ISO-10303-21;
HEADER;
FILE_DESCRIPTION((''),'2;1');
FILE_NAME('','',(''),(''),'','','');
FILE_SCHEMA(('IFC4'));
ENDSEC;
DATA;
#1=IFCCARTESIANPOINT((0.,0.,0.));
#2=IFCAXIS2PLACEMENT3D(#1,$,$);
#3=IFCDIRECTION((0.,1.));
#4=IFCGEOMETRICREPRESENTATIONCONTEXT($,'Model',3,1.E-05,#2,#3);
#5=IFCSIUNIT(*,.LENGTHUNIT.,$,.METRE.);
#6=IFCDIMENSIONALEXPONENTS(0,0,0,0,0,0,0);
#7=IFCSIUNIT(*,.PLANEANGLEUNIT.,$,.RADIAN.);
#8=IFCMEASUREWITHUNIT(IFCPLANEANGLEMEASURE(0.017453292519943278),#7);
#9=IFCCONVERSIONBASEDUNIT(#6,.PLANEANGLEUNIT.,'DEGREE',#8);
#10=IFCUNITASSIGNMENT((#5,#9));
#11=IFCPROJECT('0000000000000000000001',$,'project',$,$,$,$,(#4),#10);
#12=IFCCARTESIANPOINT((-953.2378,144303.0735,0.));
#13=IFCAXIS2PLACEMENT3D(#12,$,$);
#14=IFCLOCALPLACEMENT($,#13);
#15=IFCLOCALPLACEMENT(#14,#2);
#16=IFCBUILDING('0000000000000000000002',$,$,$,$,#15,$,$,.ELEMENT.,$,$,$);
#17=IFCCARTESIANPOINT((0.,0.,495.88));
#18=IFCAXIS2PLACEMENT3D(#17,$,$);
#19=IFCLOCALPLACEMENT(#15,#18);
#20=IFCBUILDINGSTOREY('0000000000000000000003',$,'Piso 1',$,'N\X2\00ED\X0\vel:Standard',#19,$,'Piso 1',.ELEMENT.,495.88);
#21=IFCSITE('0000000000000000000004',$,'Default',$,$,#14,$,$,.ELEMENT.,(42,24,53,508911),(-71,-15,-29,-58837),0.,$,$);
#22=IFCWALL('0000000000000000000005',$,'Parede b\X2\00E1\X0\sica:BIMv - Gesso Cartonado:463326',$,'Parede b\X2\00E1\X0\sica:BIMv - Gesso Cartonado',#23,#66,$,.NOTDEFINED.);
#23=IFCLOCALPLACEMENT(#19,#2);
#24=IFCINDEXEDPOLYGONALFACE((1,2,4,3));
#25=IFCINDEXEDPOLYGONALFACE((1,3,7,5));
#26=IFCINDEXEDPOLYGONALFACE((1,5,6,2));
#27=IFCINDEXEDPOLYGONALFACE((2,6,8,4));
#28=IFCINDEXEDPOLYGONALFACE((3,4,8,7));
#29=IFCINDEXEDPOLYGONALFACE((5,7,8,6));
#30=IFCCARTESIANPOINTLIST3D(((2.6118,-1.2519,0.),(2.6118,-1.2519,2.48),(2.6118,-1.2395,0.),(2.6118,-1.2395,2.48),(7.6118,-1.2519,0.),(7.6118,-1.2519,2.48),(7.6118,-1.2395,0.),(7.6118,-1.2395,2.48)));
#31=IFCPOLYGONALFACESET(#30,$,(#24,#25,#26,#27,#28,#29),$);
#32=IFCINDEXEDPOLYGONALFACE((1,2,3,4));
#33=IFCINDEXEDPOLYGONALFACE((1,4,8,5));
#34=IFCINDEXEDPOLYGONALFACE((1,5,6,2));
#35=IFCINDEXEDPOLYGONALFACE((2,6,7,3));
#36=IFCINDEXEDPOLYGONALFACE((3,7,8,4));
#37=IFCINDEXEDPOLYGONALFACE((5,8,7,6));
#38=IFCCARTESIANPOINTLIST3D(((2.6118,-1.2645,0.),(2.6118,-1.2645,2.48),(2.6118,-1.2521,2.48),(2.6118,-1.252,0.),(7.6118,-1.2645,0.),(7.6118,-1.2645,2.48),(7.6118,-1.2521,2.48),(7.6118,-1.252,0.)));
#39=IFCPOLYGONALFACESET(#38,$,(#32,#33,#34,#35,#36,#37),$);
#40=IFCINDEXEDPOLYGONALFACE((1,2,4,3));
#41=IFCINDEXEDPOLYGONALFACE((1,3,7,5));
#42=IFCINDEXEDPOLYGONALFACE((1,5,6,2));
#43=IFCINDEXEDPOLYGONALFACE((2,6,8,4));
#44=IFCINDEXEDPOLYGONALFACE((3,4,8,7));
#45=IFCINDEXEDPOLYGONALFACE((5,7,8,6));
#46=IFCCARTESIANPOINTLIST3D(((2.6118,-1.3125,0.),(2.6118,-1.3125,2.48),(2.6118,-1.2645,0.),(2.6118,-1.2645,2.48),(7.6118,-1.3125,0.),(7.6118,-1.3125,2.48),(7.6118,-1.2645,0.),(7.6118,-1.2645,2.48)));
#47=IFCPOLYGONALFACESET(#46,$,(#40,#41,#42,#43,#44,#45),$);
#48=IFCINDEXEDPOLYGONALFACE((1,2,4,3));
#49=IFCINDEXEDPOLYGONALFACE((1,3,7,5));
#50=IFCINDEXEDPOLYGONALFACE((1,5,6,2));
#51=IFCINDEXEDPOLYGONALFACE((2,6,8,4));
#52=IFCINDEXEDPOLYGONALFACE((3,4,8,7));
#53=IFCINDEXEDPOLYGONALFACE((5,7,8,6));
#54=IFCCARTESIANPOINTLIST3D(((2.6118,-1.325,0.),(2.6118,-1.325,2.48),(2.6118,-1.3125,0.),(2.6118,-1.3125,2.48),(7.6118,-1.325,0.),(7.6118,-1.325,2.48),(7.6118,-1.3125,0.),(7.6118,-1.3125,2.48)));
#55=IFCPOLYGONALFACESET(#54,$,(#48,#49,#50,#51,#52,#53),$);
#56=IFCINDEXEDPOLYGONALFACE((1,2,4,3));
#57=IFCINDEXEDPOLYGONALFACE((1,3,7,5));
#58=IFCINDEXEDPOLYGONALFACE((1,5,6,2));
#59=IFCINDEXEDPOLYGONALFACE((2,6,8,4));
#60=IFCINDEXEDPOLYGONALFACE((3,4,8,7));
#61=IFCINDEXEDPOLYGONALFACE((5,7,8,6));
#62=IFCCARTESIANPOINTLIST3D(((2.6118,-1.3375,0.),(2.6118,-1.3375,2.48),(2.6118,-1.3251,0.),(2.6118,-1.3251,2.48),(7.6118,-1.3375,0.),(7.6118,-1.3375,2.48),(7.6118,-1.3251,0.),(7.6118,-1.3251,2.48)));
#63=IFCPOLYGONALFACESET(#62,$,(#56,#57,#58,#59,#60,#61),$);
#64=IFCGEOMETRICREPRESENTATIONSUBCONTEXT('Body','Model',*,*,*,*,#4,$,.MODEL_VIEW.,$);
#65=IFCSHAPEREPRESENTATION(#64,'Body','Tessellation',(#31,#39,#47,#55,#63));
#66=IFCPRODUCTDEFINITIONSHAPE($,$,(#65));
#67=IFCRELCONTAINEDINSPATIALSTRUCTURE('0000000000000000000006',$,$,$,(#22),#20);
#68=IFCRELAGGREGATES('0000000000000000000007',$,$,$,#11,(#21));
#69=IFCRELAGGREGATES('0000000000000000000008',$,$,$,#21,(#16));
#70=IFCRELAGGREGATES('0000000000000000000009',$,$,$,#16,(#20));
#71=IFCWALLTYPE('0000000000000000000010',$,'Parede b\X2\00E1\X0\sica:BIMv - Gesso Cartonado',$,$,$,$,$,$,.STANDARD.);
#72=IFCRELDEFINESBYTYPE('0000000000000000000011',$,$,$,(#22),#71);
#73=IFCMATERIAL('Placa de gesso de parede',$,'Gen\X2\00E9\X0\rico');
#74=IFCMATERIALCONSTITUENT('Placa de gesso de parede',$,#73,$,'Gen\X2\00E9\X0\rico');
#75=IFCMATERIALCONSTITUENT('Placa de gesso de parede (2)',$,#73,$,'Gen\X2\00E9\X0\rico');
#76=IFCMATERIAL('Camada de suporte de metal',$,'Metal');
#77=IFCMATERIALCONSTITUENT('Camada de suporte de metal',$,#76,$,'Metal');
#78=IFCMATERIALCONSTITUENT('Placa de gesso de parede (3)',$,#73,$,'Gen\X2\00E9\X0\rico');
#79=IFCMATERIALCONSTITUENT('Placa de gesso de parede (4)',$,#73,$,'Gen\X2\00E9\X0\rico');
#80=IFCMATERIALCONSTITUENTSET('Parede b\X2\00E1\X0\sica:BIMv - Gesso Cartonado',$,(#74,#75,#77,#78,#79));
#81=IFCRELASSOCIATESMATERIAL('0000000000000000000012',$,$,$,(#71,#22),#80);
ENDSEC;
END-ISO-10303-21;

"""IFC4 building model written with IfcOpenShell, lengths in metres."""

from ifc_helpers import new_model, entity, si_unit, converted_unit, direction, frame, origin, place, context, subcontext, project, spatial, indexed_curve, outline, extrude, material, constituent, constituent_set, type_object, element, save


model = new_model("IFC4")

# Units and contexts
model_context = context("Model", 3, precision=1e-05, world=origin(), true_north=direction((0.0, 1.0)))
body_context = subcontext(model_context, "Body", "Model", "MODEL_VIEW")
ifc_project = project(units=[si_unit("LENGTHUNIT", "METRE"), converted_unit("PLANEANGLEUNIT", "DEGREE", entity("IfcPlaneAngleMeasure", 0.017453292519943278), si_unit("PLANEANGLEUNIT", "RADIAN"), dimensions=[0, 0, 0, 0, 0, 0, 0])], contexts=[model_context])

# Site, building, storey
site_placement = place(None, frame((-953.2378, 144303.0735, 0.0)))
site = spatial("IfcSite", under=ifc_project, at=site_placement, Name="Default", CompositionType="ELEMENT", RefLatitude=(42, 24, 53, 508911), RefLongitude=(-71, -15, -29, -58837), RefElevation=0.0)
building_placement = place(site_placement, origin())
building = spatial("IfcBuilding", under=site, at=building_placement, CompositionType="ELEMENT")
storey_placement = place(building_placement, frame((0.0, 0.0, 495.88)))
storey = spatial("IfcBuildingStorey", under=building, at=storey_placement, Name="Piso 1", ObjectType="Nível:Standard", LongName="Piso 1", CompositionType="ELEMENT", Elevation=495.88)

# Wall
ifc_material_1 = material(Name="Placa de gesso de parede", Category="Genérico")
ifc_constituent_1 = constituent(ifc_material_1, Name="Placa de gesso de parede", Category="Genérico")
ifc_constituent_2 = constituent(ifc_material_1, Name="Placa de gesso de parede (2)", Category="Genérico")
ifc_material_2 = material(Name="Camada de suporte de metal", Category="Metal")
ifc_constituent_3 = constituent(ifc_material_2, Name="Camada de suporte de metal", Category="Metal")
ifc_constituent_4 = constituent(ifc_material_1, Name="Placa de gesso de parede (3)", Category="Genérico")
ifc_constituent_5 = constituent(ifc_material_1, Name="Placa de gesso de parede (4)", Category="Genérico")
ifc_constituent_set = constituent_set(constituents=[ifc_constituent_1, ifc_constituent_2, ifc_constituent_3, ifc_constituent_4, ifc_constituent_5], Name="Parede básica:BIMv - Gesso Cartonado")
wall_type_1 = type_object("IfcWallType", Name="Parede básica:BIMv - Gesso Cartonado", PredefinedType="STANDARD", material=ifc_constituent_set)
wall_1_placement = place(storey_placement, frame((7.6118, -1.2885, 0.0), z_axis=(0.0, 0.0, 1.0), x_axis=(-1.0, 0.0, 0.0)))
element("IfcWall", 1, at=wall_1_placement, inside=storey, type_object=wall_type_1, material=ifc_constituent_set, Name="Parede básica:BIMv - Gesso Cartonado:463326", ObjectType="Parede básica:BIMv - Gesso Cartonado", PredefinedType="NOTDEFINED", context=body_context, shape_type="SweptSolid", body=[
    extrude(outline(indexed_curve([(-0.0062, -1.24), (0.0062, -1.24), (0.0062, 1.24), (-0.0062, 1.24), (-0.0062, -1.24)], self_intersect=False)), frame((5.0, -0.0428, 1.24), z_axis=(-1.0, 0.0, 0.0), x_axis=(0.0, 1.0, 0.0)), (0.0, 0.0, 1.0), 5.0),
    extrude(outline(indexed_curve([(-1.24, -0.0063), (1.24, -0.0062), (1.24, 0.0062), (-1.24, 0.0062), (-1.24, -0.0063)], self_intersect=False)), frame((5.0, -0.0302, 1.24), z_axis=(-1.0, 0.0, 0.0), x_axis=(0.0, 0.0, 1.0)), (0.0, 0.0, 1.0), 5.0),
    extrude(outline(indexed_curve([(-1.24, -0.024), (1.24, -0.024), (1.24, 0.024), (-1.24, 0.024), (-1.24, -0.024)], self_intersect=False)), frame((5.0, 0.0, 1.24), z_axis=(-1.0, 0.0, 0.0), x_axis=(0.0, 0.0, 1.0)), (0.0, 0.0, 1.0), 5.0),
    extrude(outline(indexed_curve([(-1.24, -0.0063), (1.24, -0.0063), (1.24, 0.0062), (-1.24, 0.0062), (-1.24, -0.0063)], self_intersect=False)), frame((5.0, 0.0303, 1.24), z_axis=(-1.0, 0.0, 0.0), x_axis=(0.0, 0.0, 1.0)), (0.0, 0.0, 1.0), 5.0),
    extrude(outline(indexed_curve([(-0.0062, -1.24), (0.0062, -1.24), (0.0062, 1.24), (-0.0062, 1.24), (-0.0062, -1.24)], self_intersect=False)), frame((5.0, 0.0428, 1.24), z_axis=(-1.0, 0.0, 0.0), x_axis=(0.0, -1.0, 0.0)), (0.0, 0.0, 1.0), 5.0),
])

save(model, "model.ifc")
